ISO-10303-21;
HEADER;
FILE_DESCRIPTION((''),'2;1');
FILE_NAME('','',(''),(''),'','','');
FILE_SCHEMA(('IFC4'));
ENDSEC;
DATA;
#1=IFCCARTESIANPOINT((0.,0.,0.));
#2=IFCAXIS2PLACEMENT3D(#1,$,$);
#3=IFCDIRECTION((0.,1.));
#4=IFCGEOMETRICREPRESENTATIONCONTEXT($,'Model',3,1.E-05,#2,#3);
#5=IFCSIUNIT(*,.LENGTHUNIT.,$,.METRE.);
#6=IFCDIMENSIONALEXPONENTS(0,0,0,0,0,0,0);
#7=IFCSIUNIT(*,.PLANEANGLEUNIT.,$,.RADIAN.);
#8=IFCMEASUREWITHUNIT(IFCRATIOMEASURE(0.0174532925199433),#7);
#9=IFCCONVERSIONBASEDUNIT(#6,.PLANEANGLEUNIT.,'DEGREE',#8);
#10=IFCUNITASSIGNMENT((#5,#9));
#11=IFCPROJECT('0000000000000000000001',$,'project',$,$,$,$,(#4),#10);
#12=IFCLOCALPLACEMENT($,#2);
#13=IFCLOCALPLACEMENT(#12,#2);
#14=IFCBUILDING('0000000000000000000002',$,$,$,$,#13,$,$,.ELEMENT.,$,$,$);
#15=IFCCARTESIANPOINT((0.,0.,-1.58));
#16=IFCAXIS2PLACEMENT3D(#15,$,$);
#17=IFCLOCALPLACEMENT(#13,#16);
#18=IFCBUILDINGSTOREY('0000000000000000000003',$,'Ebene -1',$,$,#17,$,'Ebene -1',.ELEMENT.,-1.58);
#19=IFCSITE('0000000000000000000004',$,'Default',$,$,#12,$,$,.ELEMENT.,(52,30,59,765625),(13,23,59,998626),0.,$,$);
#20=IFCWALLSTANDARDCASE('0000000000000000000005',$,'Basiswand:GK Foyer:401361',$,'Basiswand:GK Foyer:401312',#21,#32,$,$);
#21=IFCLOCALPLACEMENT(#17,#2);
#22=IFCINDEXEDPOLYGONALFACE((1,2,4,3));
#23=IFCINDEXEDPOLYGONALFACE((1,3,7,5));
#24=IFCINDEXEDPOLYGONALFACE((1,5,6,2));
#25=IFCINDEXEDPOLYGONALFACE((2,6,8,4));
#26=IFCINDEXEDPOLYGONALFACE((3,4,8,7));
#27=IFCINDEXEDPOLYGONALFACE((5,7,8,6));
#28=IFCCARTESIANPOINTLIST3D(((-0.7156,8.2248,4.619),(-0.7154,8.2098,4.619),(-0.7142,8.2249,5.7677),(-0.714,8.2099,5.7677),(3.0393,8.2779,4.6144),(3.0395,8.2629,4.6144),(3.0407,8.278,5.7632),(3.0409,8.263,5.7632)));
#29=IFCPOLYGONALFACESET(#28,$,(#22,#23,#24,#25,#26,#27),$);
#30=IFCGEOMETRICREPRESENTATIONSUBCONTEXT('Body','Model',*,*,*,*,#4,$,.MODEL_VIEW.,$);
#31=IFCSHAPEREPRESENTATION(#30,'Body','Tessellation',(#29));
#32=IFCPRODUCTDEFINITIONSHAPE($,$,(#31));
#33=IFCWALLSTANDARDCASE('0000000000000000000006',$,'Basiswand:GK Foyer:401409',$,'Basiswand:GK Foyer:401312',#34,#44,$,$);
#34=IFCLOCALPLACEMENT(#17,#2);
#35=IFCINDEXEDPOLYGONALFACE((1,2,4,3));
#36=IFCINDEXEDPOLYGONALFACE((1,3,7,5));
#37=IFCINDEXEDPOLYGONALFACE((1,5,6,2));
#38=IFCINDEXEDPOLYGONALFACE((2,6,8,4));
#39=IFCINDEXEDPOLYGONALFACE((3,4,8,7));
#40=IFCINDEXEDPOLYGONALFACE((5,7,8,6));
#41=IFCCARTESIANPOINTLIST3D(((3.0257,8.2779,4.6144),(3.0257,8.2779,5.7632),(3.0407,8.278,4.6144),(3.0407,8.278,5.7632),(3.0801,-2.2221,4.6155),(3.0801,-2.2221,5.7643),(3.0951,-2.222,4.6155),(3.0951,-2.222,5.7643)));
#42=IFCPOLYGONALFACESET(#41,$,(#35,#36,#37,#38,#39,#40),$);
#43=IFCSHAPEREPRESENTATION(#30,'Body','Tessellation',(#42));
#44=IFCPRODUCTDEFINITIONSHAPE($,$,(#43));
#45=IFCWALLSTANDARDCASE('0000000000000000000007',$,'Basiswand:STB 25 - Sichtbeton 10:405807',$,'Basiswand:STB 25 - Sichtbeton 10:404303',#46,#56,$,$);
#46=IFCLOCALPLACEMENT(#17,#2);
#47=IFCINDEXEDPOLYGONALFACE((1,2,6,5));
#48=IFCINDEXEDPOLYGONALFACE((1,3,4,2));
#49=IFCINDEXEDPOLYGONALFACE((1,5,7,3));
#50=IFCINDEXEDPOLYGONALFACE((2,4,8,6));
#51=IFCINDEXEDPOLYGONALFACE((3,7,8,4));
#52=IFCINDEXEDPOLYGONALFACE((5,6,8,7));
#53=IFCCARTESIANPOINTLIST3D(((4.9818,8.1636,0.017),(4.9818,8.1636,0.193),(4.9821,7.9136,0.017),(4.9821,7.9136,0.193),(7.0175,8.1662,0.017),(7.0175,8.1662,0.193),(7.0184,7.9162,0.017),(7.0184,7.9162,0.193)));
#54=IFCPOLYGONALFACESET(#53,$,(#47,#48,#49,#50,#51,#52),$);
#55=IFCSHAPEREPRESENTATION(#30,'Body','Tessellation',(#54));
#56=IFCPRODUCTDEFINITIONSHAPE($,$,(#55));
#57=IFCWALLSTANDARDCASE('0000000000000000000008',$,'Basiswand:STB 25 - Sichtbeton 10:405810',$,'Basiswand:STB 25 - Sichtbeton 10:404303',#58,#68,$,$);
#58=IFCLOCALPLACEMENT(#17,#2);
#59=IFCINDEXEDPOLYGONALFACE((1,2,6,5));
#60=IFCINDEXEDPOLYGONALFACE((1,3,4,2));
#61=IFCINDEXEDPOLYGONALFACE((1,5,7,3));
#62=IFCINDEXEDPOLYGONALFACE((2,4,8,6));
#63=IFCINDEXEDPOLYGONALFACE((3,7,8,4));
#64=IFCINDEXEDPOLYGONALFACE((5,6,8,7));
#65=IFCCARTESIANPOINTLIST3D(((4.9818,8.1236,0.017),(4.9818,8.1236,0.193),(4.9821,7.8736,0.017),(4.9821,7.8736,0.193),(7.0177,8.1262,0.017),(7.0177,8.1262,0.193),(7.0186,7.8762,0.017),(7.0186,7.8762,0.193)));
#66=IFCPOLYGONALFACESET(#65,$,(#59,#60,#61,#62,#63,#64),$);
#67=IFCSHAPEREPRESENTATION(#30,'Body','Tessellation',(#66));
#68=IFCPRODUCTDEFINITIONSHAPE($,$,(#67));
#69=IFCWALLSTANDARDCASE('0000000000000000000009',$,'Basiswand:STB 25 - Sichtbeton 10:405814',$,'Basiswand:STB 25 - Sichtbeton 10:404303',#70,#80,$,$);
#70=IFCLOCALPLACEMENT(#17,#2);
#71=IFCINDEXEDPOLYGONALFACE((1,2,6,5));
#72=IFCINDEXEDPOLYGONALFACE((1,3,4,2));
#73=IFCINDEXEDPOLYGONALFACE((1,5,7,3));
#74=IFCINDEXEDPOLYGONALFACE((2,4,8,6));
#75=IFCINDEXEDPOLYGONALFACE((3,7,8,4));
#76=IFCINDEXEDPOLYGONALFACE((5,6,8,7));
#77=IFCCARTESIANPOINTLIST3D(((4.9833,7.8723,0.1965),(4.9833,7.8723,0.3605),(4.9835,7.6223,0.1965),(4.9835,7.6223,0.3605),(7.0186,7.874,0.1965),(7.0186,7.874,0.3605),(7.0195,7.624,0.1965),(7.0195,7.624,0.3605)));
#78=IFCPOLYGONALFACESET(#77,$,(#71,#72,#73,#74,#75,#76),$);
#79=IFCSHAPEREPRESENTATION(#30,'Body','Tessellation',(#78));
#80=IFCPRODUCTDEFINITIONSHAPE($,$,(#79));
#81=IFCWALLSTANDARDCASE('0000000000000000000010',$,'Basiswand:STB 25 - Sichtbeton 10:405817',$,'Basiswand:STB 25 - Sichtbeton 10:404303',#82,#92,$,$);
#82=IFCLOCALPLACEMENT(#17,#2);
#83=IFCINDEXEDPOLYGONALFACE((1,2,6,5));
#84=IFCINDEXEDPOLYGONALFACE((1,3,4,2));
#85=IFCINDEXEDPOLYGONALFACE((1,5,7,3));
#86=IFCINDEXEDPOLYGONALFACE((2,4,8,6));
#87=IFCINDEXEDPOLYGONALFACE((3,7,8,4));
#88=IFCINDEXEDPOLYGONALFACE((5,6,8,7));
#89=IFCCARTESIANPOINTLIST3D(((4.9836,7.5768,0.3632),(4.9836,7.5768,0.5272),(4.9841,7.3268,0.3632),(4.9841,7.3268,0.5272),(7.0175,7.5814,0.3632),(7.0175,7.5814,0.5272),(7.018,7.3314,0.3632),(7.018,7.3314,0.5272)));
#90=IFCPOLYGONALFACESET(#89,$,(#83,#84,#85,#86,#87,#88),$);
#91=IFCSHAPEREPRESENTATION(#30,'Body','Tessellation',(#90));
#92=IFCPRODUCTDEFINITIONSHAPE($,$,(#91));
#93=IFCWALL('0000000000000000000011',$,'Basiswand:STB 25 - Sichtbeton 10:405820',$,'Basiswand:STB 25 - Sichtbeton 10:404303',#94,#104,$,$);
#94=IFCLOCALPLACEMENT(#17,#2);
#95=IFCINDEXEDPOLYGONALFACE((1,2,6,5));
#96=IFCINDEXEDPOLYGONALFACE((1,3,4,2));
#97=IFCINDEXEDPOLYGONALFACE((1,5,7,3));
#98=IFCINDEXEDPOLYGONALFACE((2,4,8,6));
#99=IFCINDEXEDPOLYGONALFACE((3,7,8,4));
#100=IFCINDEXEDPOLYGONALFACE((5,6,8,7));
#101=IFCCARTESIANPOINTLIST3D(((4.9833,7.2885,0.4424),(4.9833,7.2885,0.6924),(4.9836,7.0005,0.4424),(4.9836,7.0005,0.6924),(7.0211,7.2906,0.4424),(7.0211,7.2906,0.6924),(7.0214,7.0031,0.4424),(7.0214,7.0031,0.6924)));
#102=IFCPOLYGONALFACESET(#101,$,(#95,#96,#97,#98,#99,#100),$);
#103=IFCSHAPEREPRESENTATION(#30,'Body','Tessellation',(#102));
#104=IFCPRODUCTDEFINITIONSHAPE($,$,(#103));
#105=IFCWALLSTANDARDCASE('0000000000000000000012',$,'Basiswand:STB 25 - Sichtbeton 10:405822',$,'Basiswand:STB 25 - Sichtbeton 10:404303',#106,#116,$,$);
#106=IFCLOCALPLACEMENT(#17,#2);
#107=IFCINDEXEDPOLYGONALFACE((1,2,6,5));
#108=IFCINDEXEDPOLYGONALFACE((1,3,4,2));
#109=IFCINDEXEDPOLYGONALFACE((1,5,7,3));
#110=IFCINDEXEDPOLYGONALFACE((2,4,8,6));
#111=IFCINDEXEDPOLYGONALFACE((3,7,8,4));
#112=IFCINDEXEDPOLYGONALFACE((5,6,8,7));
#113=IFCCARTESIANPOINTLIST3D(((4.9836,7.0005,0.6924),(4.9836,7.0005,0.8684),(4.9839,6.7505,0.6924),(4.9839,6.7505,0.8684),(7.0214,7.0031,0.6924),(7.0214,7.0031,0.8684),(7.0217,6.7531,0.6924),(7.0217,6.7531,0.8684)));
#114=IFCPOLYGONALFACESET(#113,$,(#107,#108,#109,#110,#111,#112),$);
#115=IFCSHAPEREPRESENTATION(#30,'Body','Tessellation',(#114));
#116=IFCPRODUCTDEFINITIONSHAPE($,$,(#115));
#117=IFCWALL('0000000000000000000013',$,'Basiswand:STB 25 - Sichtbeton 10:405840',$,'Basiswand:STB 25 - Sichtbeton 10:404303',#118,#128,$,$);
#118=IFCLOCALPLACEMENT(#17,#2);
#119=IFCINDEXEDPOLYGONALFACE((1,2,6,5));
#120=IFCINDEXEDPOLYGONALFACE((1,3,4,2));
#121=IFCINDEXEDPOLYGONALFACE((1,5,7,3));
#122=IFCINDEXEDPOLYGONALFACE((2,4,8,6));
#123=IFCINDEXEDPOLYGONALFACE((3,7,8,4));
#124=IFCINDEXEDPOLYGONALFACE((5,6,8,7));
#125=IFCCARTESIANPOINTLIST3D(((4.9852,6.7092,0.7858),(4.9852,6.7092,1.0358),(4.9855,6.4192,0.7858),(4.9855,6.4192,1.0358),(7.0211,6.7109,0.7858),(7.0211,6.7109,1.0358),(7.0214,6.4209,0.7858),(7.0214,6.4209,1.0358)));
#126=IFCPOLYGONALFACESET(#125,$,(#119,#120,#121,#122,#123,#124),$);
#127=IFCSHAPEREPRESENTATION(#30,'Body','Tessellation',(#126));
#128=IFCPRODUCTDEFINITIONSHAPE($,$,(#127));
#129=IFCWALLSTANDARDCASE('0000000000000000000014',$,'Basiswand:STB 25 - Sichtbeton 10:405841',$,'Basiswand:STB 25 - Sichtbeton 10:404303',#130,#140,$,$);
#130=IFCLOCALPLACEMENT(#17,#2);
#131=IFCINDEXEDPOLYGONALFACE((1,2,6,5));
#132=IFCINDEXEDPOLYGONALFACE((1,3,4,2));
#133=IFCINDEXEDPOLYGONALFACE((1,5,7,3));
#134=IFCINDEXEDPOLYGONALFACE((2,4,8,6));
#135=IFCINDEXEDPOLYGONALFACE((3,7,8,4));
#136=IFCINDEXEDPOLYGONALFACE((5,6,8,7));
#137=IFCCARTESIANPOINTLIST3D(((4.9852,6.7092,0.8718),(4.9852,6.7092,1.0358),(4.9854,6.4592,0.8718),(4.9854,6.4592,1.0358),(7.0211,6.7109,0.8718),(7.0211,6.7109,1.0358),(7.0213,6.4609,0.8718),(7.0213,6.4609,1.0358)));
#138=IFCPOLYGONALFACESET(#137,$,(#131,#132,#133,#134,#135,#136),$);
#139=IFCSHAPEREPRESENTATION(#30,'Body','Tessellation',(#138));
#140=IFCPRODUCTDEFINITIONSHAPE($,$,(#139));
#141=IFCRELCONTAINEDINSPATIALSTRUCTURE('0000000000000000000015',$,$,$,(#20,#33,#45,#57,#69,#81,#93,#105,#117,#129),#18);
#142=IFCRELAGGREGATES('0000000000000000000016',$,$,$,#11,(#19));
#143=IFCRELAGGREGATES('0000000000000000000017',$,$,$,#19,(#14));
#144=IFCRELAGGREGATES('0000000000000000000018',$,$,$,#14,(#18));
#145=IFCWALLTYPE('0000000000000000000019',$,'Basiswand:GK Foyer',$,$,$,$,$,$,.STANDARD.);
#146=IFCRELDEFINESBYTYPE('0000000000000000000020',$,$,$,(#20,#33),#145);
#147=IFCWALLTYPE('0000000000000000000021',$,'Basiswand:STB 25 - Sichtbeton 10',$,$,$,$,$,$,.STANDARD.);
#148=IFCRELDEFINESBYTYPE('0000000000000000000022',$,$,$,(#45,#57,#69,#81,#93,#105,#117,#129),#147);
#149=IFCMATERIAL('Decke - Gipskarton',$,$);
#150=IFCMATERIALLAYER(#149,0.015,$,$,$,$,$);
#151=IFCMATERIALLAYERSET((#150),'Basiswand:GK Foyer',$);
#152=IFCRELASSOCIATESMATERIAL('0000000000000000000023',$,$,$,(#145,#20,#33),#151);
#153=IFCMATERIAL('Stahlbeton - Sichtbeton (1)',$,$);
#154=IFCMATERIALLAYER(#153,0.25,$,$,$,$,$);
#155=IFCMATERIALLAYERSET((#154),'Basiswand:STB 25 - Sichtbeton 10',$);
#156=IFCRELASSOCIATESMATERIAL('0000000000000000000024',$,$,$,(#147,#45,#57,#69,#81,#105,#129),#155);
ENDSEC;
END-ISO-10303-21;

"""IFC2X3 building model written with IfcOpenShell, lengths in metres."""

from ifc_helpers import new_model, entity, si_unit, converted_unit, direction, frame, frame_2d, origin, place, context, subcontext, project, spatial, polyline, rectangle, outline, extrude, clip, halfspace, material, layer, layer_set, layer_usage, type_object, element, save


model = new_model("IFC2X3")

# Units and contexts
model_context = context("Model", 3, precision=1e-05, world=origin(), true_north=direction((0.0, 1.0)))
body_context = subcontext(model_context, "Body", "Model", "MODEL_VIEW")
ifc_project = project(units=[si_unit("LENGTHUNIT", "METRE"), converted_unit("PLANEANGLEUNIT", "DEGREE", entity("IfcRatioMeasure", 0.0174532925199433), si_unit("PLANEANGLEUNIT", "RADIAN"), dimensions=[0, 0, 0, 0, 0, 0, 0])], contexts=[model_context])

# Site, building, storey
site_placement = place(None, origin())
site = spatial("IfcSite", under=ifc_project, at=site_placement, Name="Default", CompositionType="ELEMENT", RefLatitude=(52, 30, 59, 765625), RefLongitude=(13, 23, 59, 998626), RefElevation=0.0)
building_placement = place(site_placement, origin())
building = spatial("IfcBuilding", under=site, at=building_placement, CompositionType="ELEMENT")
storey_placement = place(building_placement, frame((0.0, 0.0, -1.58)))
storey = spatial("IfcBuildingStorey", under=building, at=storey_placement, Name="Ebene -1", LongName="Ebene -1", CompositionType="ELEMENT", Elevation=-1.58)

# Walls
ifc_material_1 = material(Name="Stahlbeton - Sichtbeton (1)")
ifc_material_2 = material(Name="Decke - Gipskarton")
ifc_layer_1 = layer(ifc_material_2, 0.015)
ifc_layer_set_1 = layer_set([ifc_layer_1], Name="Basiswand:GK Foyer")
ifc_layer_usage_1 = layer_usage(ifc_layer_set_1, "AXIS2", "POSITIVE", -0.0075)
wall_type_1 = type_object("IfcWallType", Name="Basiswand:GK Foyer", PredefinedType="STANDARD", material=ifc_layer_set_1)
wall_1_placement = place(storey_placement, frame((3.0408, 8.2705, 4.6144), z_axis=(0.0, 0.0, 1.0), x_axis=(-0.9999, -0.014139, 0.0)))
element("IfcWallStandardCase", 1, at=wall_1_placement, inside=storey, type_object=wall_type_1, material=ifc_layer_usage_1, Name="Basiswand:GK Foyer:401361", ObjectType="Basiswand:GK Foyer:401312", context=body_context, shape_type="Clipping", body=[
    clip(clip(clip(clip(extrude(rectangle(XDim=3.7567, YDim=0.015, at=frame_2d((1.8783, 0.0), x_axis=(-1.0, 0.0))), origin(), (0.0, 0.0, 1.0), 1.1533), halfspace(frame((0.0014, -0.0075, 0.0), z_axis=(-0.999999, 0.0, -0.001217), x_axis=(0.0, 1.0, 0.0)), False)), halfspace(frame((3.7567, -0.0075, 0.0046), z_axis=(0.001217, 0.0, -0.999999), x_axis=(0.0, 1.0, 0.0)), False)), halfspace(frame((3.7553, -0.0075, 1.1533), z_axis=(0.999999, 0.0, 0.001217), x_axis=(0.0, 1.0, 0.0)), False)), halfspace(frame((0.0, -0.0075, 1.1488), z_axis=(-0.001217, 0.0, 0.999999), x_axis=(0.0, 1.0, 0.0)), False)),
])
ifc_layer_usage_2 = layer_usage(ifc_layer_set_1, "AXIS2", "POSITIVE", -0.0075)
wall_2_placement = place(storey_placement, frame((3.0876, -2.2221, 4.6144), z_axis=(0.0, 0.0, 1.0), x_axis=(-0.005187, 0.999987, 0.0)))
element("IfcWallStandardCase", 2, at=wall_2_placement, inside=storey, type_object=wall_type_1, material=ifc_layer_usage_2, Name="Basiswand:GK Foyer:401409", ObjectType="Basiswand:GK Foyer:401312", context=body_context, shape_type="Clipping", body=[
    clip(clip(clip(clip(extrude(rectangle(XDim=10.5001, YDim=0.015, at=frame_2d((5.2501, 0.0), x_axis=(-1.0, 0.0))), origin(), (0.0, 0.0, 1.0), 1.1499), halfspace(frame((0.0, -0.0075, 0.0011), z_axis=(-1.0, 0.0, 0.000107), x_axis=(0.0, 1.0, 0.0)), False)), halfspace(frame((10.5, -0.0075, 0.0), z_axis=(-0.000108, 0.0, -1.0), x_axis=(0.0, 1.0, 0.0)), False)), halfspace(frame((10.5001, -0.0075, 1.1488), z_axis=(1.0, 0.0, -0.000107), x_axis=(0.0, 1.0, 0.0)), False)), halfspace(frame((0.0001, -0.0075, 1.1499), z_axis=(0.000107, 0.0, 1.0), x_axis=(0.0, 1.0, 0.0)), False)),
])
ifc_layer_2 = layer(ifc_material_1, 0.25)
ifc_layer_set_2 = layer_set([ifc_layer_2], Name="Basiswand:STB 25 - Sichtbeton 10")
ifc_layer_usage_3 = layer_usage(ifc_layer_set_2, "AXIS2", "POSITIVE", -0.125)
wall_type_2 = type_object("IfcWallType", Name="Basiswand:STB 25 - Sichtbeton 10", PredefinedType="STANDARD", material=ifc_layer_set_2)
wall_3_placement = place(storey_placement, frame((7.0183, 8.0412, 0.017), z_axis=(0.0, 0.0, 1.0), x_axis=(-0.999999, -0.001264, 0.0)))
element("IfcWallStandardCase", 3, at=wall_3_placement, inside=storey, type_object=wall_type_2, material=ifc_layer_usage_3, Name="Basiswand:STB 25 - Sichtbeton 10:405807", ObjectType="Basiswand:STB 25 - Sichtbeton 10:404303", context=body_context, shape_type="SweptSolid", body=[
    extrude(outline(polyline([(2.0363, -0.125), (2.0363, 0.125), (0.0, 0.125), (0.0006, -0.125), (2.0363, -0.125)])), origin(), (0.0, 0.0, 1.0), 0.176),
])
ifc_layer_usage_4 = layer_usage(ifc_layer_set_2, "AXIS2", "POSITIVE", -0.125)
wall_4_placement = place(storey_placement, frame((4.982, 7.9986, 0.017), z_axis=(0.0, 0.0, 1.0), x_axis=(0.999999, 0.001264, 0.0)))
element("IfcWallStandardCase", 4, at=wall_4_placement, inside=storey, type_object=wall_type_2, material=ifc_layer_usage_4, Name="Basiswand:STB 25 - Sichtbeton 10:405810", ObjectType="Basiswand:STB 25 - Sichtbeton 10:404303", context=body_context, shape_type="SweptSolid", body=[
    extrude(outline(polyline([(2.0364, -0.125), (2.0358, 0.125), (0.0, 0.125), (0.0, -0.125), (2.0364, -0.125)])), origin(), (0.0, 0.0, 1.0), 0.176),
])
ifc_layer_usage_5 = layer_usage(ifc_layer_set_2, "AXIS2", "POSITIVE", -0.125)
wall_5_placement = place(storey_placement, frame((7.0194, 7.749, 0.1965), z_axis=(0.0, 0.0, 1.0), x_axis=(-1.0, -0.000827, 0.0)))
element("IfcWallStandardCase", 5, at=wall_5_placement, inside=storey, type_object=wall_type_2, material=ifc_layer_usage_5, Name="Basiswand:STB 25 - Sichtbeton 10:405814", ObjectType="Basiswand:STB 25 - Sichtbeton 10:404303", context=body_context, shape_type="SweptSolid", body=[
    extrude(outline(polyline([(2.0359, -0.125), (2.0359, 0.125), (0.0, 0.125), (0.0007, -0.125), (2.0359, -0.125)])), origin(), (0.0, 0.0, 1.0), 0.164),
])
ifc_layer_usage_6 = layer_usage(ifc_layer_set_2, "AXIS2", "POSITIVE", -0.125)
wall_6_placement = place(storey_placement, frame((7.0177, 7.4564, 0.3632), z_axis=(0.0, 0.0, 1.0), x_axis=(-0.999998, -0.002231, 0.0)))
element("IfcWallStandardCase", 6, at=wall_6_placement, inside=storey, type_object=wall_type_2, material=ifc_layer_usage_6, Name="Basiswand:STB 25 - Sichtbeton 10:405817", ObjectType="Basiswand:STB 25 - Sichtbeton 10:404303", context=body_context, shape_type="SweptSolid", body=[
    extrude(rectangle(XDim=2.0339, YDim=0.25, at=frame_2d((1.0169, 0.0), x_axis=(-1.0, 0.0))), origin(), (0.0, 0.0, 1.0), 0.164),
])
wall_7_placement = place(storey_placement, frame((4.9833, 7.0005, 0.4424)))
element("IfcWall", 7, at=wall_7_placement, inside=storey, type_object=wall_type_2, Name="Basiswand:STB 25 - Sichtbeton 10:405820", ObjectType="Basiswand:STB 25 - Sichtbeton 10:404303", context=body_context, shape_type="SweptSolid", body=[
    extrude(outline(polyline([(-0.1439, -1.0189), (0.1441, -1.0189), (0.1436, 1.0189), (-0.1439, 1.0189), (-0.1439, -1.0189)])), frame((1.0191, 0.1452, 0.0), z_axis=(0.0, 0.0, 1.0), x_axis=(0.001024, -0.999999, 0.0)), (0.0, 0.0, 1.0), 0.25),
])
ifc_layer_usage_7 = layer_usage(ifc_layer_set_2, "AXIS2", "POSITIVE", -0.125)
wall_8_placement = place(storey_placement, frame((7.0216, 6.8781, 0.6924), z_axis=(0.0, 0.0, 1.0), x_axis=(-0.999999, -0.001264, 0.0)))
element("IfcWallStandardCase", 8, at=wall_8_placement, inside=storey, type_object=wall_type_2, material=ifc_layer_usage_7, Name="Basiswand:STB 25 - Sichtbeton 10:405822", ObjectType="Basiswand:STB 25 - Sichtbeton 10:404303", context=body_context, shape_type="Clipping", body=[
    clip(clip(extrude(rectangle(XDim=2.0379, YDim=0.25, at=frame_2d((1.0189, 0.0), x_axis=(-1.0, 0.0))), origin(), (0.0, 0.0, 1.0), 0.176), halfspace(frame((2.0379, -0.125, 0.0), z_axis=(0.0, 0.0, -1.0), x_axis=(0.0, 1.0, 0.0)), False)), halfspace(frame((0.0, -0.125, 0.176), z_axis=(0.0, 0.0, 1.0), x_axis=(0.0, 1.0, 0.0)), False)),
])
wall_9_placement = place(storey_placement, frame((4.9852, 6.4192, 0.7858)))
element("IfcWall", 9, at=wall_9_placement, inside=storey, type_object=wall_type_2, Name="Basiswand:STB 25 - Sichtbeton 10:405840", ObjectType="Basiswand:STB 25 - Sichtbeton 10:404303", context=body_context, shape_type="SweptSolid", body=[
    extrude(outline(polyline([(-1.0179, -0.145), (1.018, -0.145), (1.0179, 0.145), (-1.018, 0.145), (-1.0179, -0.145)])), frame((1.0181, 0.1458, 0.0), z_axis=(0.0, 0.0, 1.0), x_axis=(1.0, 0.000827, 0.0)), (0.0, 0.0, 1.0), 0.25),
])
ifc_layer_usage_8 = layer_usage(ifc_layer_set_2, "AXIS2", "POSITIVE", -0.125)
wall_10_placement = place(storey_placement, frame((7.0212, 6.5859, 0.7428), z_axis=(0.0, 0.0, 1.0), x_axis=(-1.0, -0.000827, 0.0)))
element("IfcWallStandardCase", 10, at=wall_10_placement, inside=storey, type_object=wall_type_2, material=ifc_layer_usage_8, Name="Basiswand:STB 25 - Sichtbeton 10:405841", ObjectType="Basiswand:STB 25 - Sichtbeton 10:404303", context=body_context, shape_type="Clipping", body=[
    clip(extrude(rectangle(XDim=2.0359, YDim=0.25, at=frame_2d((1.018, 0.0), x_axis=(-1.0, 0.0))), origin(), (0.0, 0.0, 1.0), 0.293), halfspace(frame((2.0359, -0.125, 0.129), z_axis=(0.0, 0.0, -1.0), x_axis=(0.0, 1.0, 0.0)), False)),
])

save(model, "model.ifc")
